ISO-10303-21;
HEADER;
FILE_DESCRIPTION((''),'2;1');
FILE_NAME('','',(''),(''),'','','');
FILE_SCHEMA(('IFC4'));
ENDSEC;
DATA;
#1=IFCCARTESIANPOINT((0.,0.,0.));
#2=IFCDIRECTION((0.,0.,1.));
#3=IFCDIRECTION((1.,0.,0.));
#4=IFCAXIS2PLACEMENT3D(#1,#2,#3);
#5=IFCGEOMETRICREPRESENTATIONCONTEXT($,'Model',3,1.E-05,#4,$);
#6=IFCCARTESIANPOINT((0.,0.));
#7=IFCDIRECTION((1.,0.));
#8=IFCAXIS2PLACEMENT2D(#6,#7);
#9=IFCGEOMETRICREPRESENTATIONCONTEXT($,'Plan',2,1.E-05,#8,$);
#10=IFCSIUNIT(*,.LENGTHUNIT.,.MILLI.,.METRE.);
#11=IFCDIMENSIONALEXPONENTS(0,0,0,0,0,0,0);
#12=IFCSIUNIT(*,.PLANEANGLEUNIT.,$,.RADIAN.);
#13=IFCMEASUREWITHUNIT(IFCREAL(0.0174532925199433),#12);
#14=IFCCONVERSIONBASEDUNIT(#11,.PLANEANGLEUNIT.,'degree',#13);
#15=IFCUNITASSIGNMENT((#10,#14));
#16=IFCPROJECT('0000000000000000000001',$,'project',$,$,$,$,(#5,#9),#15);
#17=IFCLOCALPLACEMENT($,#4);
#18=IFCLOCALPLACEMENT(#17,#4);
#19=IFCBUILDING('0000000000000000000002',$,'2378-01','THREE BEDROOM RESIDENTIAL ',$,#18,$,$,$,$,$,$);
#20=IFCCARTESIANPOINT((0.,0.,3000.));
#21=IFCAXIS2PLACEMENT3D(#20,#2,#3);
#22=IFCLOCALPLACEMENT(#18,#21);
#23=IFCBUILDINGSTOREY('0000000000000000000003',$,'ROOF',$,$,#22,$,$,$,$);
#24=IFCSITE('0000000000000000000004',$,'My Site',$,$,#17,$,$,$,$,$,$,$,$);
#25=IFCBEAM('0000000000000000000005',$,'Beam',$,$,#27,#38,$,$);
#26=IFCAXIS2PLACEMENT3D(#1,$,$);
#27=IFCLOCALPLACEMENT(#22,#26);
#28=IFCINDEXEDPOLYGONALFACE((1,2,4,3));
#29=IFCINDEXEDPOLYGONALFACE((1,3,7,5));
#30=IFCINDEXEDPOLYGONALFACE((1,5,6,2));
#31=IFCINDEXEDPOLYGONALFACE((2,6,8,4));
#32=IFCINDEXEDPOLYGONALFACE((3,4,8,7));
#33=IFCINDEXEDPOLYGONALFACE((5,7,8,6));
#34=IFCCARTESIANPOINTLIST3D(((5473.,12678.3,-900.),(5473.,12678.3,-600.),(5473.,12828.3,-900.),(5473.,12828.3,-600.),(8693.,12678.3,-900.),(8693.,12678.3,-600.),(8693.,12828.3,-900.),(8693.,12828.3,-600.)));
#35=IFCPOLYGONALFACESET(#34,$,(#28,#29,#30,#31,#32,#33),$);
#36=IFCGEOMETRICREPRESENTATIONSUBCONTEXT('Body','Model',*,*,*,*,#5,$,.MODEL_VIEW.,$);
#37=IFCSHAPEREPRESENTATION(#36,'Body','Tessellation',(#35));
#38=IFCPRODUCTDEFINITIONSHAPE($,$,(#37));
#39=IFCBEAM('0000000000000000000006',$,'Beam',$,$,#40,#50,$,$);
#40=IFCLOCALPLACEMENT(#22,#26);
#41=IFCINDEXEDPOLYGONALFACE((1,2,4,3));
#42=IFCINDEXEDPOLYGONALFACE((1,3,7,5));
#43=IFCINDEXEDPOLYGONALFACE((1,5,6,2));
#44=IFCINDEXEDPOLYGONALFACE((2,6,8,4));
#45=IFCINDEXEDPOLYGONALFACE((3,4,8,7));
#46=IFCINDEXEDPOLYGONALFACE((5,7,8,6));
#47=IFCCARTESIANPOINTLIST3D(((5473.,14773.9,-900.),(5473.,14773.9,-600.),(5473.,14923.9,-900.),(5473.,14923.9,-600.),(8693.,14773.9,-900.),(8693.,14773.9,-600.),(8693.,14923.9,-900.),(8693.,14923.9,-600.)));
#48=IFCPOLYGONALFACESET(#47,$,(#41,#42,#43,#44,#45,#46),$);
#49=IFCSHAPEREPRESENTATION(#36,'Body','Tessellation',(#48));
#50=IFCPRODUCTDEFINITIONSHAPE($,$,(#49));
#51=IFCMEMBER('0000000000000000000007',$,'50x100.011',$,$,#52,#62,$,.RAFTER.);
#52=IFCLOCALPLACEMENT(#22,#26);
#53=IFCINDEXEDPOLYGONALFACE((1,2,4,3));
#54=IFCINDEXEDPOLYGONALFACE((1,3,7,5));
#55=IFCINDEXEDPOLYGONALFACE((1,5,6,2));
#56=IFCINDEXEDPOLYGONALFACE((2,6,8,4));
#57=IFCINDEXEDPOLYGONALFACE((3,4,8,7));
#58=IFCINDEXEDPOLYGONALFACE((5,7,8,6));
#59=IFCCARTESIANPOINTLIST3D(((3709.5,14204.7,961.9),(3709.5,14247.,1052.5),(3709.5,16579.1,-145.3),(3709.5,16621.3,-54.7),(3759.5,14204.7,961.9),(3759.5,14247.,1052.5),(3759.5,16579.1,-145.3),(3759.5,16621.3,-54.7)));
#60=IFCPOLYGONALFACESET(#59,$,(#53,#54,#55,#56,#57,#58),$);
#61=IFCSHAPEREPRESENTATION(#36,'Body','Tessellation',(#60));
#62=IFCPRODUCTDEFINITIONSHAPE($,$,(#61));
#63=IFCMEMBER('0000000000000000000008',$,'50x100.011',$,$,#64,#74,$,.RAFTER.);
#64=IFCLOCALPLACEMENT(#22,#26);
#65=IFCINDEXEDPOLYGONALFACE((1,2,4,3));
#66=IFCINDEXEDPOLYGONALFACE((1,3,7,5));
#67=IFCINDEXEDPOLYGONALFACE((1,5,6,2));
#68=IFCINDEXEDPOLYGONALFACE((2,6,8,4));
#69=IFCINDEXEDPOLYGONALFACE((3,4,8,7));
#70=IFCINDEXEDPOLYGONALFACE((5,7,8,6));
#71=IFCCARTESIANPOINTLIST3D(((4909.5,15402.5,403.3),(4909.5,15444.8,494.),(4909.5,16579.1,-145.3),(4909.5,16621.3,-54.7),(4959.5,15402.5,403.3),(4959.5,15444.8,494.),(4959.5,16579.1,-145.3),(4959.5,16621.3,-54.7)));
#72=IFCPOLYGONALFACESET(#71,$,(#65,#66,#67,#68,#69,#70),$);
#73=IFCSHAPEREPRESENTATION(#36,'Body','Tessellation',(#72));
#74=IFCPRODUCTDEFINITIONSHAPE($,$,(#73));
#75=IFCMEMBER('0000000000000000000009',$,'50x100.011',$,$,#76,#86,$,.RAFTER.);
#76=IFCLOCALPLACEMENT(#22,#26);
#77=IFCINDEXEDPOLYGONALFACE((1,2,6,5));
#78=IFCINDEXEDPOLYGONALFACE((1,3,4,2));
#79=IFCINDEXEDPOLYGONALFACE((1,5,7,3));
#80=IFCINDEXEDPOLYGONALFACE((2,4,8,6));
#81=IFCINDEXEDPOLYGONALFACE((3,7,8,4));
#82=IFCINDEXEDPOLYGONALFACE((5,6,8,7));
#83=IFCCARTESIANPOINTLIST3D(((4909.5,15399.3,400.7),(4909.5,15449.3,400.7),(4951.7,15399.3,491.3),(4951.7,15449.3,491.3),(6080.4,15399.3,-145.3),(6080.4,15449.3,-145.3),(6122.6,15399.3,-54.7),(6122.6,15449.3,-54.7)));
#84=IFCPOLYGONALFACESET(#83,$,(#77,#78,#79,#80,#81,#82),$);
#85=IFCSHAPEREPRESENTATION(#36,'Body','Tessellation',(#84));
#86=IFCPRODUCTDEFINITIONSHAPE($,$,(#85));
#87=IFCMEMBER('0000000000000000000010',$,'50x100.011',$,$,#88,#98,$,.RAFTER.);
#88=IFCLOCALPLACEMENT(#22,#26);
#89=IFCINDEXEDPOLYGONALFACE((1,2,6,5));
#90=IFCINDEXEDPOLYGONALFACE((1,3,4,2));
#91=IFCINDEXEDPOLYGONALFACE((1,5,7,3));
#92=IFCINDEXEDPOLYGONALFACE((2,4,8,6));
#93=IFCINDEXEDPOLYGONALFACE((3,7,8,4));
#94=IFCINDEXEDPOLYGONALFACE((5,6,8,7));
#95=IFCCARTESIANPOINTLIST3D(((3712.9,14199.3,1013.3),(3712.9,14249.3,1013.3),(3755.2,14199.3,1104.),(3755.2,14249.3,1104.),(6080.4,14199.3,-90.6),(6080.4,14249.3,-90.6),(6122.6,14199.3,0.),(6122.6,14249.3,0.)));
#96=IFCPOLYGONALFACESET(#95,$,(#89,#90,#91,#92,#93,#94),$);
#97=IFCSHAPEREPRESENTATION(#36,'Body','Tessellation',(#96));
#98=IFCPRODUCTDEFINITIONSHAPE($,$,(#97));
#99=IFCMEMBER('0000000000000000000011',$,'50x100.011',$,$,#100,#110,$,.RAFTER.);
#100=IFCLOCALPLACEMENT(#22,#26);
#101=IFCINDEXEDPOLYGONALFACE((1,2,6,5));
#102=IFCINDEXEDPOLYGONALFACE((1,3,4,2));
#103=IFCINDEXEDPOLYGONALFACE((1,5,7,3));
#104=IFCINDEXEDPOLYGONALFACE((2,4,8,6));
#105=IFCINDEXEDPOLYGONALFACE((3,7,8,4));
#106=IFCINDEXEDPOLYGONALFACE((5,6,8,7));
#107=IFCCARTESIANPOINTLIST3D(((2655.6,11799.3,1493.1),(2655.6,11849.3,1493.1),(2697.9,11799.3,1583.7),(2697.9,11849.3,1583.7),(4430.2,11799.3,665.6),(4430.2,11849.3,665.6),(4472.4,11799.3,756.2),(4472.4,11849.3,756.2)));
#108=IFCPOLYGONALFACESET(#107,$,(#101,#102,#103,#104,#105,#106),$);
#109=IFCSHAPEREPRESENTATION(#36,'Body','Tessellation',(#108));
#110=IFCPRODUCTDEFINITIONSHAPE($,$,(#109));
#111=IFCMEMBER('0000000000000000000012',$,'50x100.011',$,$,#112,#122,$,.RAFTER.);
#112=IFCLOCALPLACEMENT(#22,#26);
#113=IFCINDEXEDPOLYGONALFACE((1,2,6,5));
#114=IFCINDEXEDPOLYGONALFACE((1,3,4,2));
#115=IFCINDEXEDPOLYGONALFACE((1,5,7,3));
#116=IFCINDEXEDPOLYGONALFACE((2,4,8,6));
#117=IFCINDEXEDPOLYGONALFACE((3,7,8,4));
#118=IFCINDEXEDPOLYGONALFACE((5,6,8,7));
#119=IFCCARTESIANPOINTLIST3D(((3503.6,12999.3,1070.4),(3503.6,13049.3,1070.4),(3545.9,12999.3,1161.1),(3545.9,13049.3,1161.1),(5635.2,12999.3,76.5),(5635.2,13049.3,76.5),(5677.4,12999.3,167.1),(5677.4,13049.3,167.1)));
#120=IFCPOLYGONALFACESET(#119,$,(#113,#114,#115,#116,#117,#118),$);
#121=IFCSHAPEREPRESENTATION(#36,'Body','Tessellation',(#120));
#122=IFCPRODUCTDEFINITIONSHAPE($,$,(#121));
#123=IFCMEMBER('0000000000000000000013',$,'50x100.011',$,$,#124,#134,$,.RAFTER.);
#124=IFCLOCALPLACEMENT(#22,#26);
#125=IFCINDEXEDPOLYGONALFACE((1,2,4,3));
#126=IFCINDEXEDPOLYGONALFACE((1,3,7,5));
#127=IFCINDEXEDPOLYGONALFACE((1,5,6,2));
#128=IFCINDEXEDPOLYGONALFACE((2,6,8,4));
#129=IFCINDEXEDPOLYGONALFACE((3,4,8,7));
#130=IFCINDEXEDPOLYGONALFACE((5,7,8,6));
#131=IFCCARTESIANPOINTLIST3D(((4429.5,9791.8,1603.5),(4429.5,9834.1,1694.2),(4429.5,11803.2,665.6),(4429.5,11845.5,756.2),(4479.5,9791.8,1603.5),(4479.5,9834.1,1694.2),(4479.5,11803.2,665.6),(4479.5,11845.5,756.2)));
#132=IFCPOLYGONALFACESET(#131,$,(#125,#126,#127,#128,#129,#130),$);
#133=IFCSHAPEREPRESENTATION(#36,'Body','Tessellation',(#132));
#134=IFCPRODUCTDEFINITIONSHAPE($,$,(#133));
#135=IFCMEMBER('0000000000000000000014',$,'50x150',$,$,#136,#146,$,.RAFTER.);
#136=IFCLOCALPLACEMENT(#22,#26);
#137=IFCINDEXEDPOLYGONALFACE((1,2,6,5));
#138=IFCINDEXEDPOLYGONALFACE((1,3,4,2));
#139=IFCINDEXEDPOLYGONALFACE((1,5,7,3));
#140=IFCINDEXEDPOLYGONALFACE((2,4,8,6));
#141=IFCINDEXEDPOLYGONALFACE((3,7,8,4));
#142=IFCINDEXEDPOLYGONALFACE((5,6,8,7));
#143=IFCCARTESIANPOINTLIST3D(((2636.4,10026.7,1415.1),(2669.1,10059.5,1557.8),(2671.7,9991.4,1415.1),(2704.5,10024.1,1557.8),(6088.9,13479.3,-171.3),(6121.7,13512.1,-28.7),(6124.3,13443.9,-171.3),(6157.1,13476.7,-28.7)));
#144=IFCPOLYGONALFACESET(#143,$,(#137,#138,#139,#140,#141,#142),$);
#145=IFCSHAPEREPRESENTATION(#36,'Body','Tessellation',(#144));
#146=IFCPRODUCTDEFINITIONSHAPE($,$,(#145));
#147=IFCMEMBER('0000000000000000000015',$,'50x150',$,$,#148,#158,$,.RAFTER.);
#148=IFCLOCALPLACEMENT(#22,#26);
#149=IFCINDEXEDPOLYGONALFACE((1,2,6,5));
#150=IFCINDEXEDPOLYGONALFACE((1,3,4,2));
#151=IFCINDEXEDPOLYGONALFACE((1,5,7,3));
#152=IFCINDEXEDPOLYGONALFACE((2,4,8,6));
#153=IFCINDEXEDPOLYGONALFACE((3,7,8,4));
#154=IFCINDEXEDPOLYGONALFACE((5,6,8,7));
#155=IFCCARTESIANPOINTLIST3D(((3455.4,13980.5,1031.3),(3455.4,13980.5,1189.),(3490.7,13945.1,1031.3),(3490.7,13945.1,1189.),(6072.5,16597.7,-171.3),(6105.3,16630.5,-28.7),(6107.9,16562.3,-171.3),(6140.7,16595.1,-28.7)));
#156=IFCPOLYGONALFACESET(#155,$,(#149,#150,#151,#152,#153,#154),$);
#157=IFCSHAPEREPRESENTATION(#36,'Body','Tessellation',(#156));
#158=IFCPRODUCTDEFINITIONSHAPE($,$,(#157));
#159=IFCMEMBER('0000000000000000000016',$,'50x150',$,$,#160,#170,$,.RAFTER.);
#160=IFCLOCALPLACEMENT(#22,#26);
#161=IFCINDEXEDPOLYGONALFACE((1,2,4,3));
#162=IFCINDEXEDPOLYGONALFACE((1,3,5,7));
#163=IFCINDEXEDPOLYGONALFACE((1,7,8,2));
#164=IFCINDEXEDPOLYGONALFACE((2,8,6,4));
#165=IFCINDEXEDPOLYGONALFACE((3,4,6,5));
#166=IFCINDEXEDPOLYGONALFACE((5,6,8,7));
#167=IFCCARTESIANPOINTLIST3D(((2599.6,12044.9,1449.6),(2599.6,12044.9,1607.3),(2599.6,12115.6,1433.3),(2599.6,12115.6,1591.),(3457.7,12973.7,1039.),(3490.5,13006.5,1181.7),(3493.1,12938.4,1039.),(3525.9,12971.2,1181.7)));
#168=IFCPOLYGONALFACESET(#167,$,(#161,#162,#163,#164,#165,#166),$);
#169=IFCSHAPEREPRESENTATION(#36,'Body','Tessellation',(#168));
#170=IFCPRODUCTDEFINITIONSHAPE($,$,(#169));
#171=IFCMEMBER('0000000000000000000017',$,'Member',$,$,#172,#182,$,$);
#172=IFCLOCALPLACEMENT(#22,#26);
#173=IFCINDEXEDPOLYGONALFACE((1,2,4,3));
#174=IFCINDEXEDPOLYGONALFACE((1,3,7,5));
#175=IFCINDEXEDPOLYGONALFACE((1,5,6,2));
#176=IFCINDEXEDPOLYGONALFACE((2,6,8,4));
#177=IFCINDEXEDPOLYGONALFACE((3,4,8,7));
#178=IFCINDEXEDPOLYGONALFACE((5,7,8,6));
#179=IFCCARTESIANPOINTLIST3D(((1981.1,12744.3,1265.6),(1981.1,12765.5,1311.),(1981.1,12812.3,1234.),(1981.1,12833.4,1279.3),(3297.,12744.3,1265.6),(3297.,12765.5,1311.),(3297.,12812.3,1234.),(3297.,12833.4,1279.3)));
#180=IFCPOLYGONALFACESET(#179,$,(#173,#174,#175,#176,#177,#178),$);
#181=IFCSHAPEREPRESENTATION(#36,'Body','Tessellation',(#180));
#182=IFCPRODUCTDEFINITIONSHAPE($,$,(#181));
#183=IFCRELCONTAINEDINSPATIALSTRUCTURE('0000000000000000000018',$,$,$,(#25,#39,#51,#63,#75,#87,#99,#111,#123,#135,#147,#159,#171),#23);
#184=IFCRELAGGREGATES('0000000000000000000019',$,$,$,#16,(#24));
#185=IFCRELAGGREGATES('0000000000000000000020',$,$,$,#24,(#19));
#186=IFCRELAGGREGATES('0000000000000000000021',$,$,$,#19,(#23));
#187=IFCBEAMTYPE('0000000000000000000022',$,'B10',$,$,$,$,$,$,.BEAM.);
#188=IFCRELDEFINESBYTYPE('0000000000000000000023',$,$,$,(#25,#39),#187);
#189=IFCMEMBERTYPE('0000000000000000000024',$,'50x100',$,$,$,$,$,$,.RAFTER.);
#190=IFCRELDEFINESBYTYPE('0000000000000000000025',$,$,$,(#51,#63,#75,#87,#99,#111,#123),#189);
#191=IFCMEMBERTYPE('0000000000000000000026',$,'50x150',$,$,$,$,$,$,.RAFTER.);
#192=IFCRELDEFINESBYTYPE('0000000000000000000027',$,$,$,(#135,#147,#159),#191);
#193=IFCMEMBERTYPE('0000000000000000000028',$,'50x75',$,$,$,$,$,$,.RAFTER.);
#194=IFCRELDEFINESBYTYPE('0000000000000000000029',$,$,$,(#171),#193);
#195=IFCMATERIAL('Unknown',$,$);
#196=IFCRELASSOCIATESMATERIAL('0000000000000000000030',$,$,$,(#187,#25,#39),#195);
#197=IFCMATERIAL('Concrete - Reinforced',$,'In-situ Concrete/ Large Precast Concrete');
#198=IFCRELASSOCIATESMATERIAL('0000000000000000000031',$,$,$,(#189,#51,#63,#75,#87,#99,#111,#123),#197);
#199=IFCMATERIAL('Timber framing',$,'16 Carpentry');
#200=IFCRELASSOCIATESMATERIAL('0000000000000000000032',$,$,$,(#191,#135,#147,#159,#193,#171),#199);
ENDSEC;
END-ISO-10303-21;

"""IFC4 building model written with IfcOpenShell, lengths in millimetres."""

from ifc_helpers import new_model, entity, si_unit, converted_unit, frame, origin_with_axes, origin_2d_with_axis, place, context, subcontext, project, spatial, rectangle, extrude, clip, halfspace, material, material_profile, profile_set, profile_usage, type_object, element, save


model = new_model("IFC4")

# Units and contexts
model_context = context("Model", 3, precision=1e-05, world=origin_with_axes())
plan_context = context("Plan", 2, precision=1e-05, world=origin_2d_with_axis())
body_context = subcontext(model_context, "Body", "Model", "MODEL_VIEW")
ifc_project = project(units=[si_unit("LENGTHUNIT", "METRE", prefix="MILLI"), converted_unit("PLANEANGLEUNIT", "degree", entity("IfcReal", 0.0174532925199433), si_unit("PLANEANGLEUNIT", "RADIAN"), dimensions=[0, 0, 0, 0, 0, 0, 0])], contexts=[model_context, plan_context])

# Site, building, storey
site_placement = place(None, origin_with_axes())
site = spatial("IfcSite", under=ifc_project, at=site_placement, Name="My Site")
building_placement = place(site_placement, origin_with_axes())
building = spatial("IfcBuilding", under=site, at=building_placement, Name="2378-01", Description="THREE BEDROOM RESIDENTIAL ")
storey_placement = place(building_placement, frame((0.0, 0.0, 3000.0), z_axis=(0.0, 0.0, 1.0), x_axis=(1.0, 0.0, 0.0)))
storey = spatial("IfcBuildingStorey", under=building, at=storey_placement, Name="ROOF")

# Beams
ifc_material_1 = material(Name="Unknown")
ifc_material_profile_1 = material_profile(ifc_material_1, rectangle(XDim=150.0, YDim=300.0))
ifc_profile_set_1 = profile_set([ifc_material_profile_1])
ifc_profile_usage_1 = profile_usage(ifc_profile_set_1, cardinal=5)
beam_type = type_object("IfcBeamType", Name="B10", PredefinedType="BEAM", material=ifc_profile_set_1)
beam_1_placement = place(storey_placement, frame((5473.0, 12753.3, -750.0), z_axis=(1.0, 0.0, 0.0), x_axis=(0.0, 1.0, 0.0)))
element("IfcBeam", 1, at=beam_1_placement, inside=storey, type_object=beam_type, material=ifc_profile_usage_1, Name="Beam", context=body_context, shape_type="SweptSolid", body=[
    extrude(rectangle(XDim=150.0, YDim=300.0), origin_with_axes(), (0.0, 0.0, 1.0), 3220.0),
])
ifc_profile_usage_2 = profile_usage(ifc_profile_set_1, cardinal=5)
beam_2_placement = place(storey_placement, frame((5473.0, 14848.9, -750.0), z_axis=(1.0, 0.0, 0.0), x_axis=(0.0, 1.0, 0.0)))
element("IfcBeam", 2, at=beam_2_placement, inside=storey, type_object=beam_type, material=ifc_profile_usage_2, Name="Beam", context=body_context, shape_type="SweptSolid", body=[
    extrude(rectangle(XDim=150.0, YDim=300.0), origin_with_axes(), (0.0, 0.0, 1.0), 3220.0),
])

# Members
ifc_material_2 = material(Name="Concrete - Reinforced", Category="In-situ Concrete/ Large Precast Concrete")
ifc_material_profile_2 = material_profile(ifc_material_2, rectangle(XDim=50.0, YDim=100.0), Name="Core Layer", Category="LoadBearing", Priority=1)
ifc_profile_set_2 = profile_set([ifc_material_profile_2], Name="wood")
ifc_profile_usage_3 = profile_usage(ifc_profile_set_2)
member_type_1 = type_object("IfcMemberType", Name="50x100", PredefinedType="RAFTER", material=ifc_profile_set_2)
member_1_placement = place(storey_placement, frame((3734.5, 16600.2, -100.0), z_axis=(0.0, -0.906308, 0.422618), x_axis=(1.0, 0.0, 0.0)))
element("IfcMember", 3, at=member_1_placement, inside=storey, type_object=member_type_1, material=ifc_profile_usage_3, Name="50x100.011", PredefinedType="RAFTER", context=body_context, shape_type="SweptSolid", body=[
    extrude(rectangle(XDim=50.0, YDim=100.0), origin_with_axes(), (0.0, 0.0, 1.0), 2619.8),
])
ifc_profile_usage_4 = profile_usage(ifc_profile_set_2)
member_2_placement = place(storey_placement, frame((4934.5, 16600.2, -100.0), z_axis=(0.0, -0.906308, 0.422618), x_axis=(1.0, 0.0, 0.0)))
element("IfcMember", 4, at=member_2_placement, inside=storey, type_object=member_type_1, material=ifc_profile_usage_4, Name="50x100.011", PredefinedType="RAFTER", context=body_context, shape_type="SweptSolid", body=[
    extrude(rectangle(XDim=50.0, YDim=100.0), origin_with_axes(), (0.0, 0.0, 1.0), 1298.2),
])
ifc_profile_usage_5 = profile_usage(ifc_profile_set_2)
member_3_placement = place(storey_placement, frame((6101.5, 15424.3, -100.0), z_axis=(-0.906308, 0.0, 0.422618), x_axis=(0.0, -1.0, 0.0)))
element("IfcMember", 5, at=member_3_placement, inside=storey, type_object=member_type_1, material=ifc_profile_usage_5, Name="50x100.011", PredefinedType="RAFTER", context=body_context, shape_type="SweptSolid", body=[
    extrude(rectangle(XDim=50.0, YDim=100.0), origin_with_axes(), (0.0, 0.0, 1.0), 1292.0),
])
ifc_profile_usage_6 = profile_usage(ifc_profile_set_2)
member_4_placement = place(storey_placement, frame((6101.5, 14224.3, -45.3), z_axis=(-0.906308, 0.0, 0.422618), x_axis=(0.0, -1.0, 0.0)))
element("IfcMember", 6, at=member_4_placement, inside=storey, type_object=member_type_1, material=ifc_profile_usage_6, Name="50x100.011", PredefinedType="RAFTER", context=body_context, shape_type="SweptSolid", body=[
    extrude(rectangle(XDim=50.0, YDim=100.0), origin_with_axes(), (0.0, 0.0, 1.0), 2612.2),
])
ifc_profile_usage_7 = profile_usage(ifc_profile_set_2)
member_5_placement = place(storey_placement, frame((4451.3, 11824.3, 710.9), z_axis=(-0.906308, 0.0, 0.422618), x_axis=(0.0, -1.0, 0.0)))
element("IfcMember", 7, at=member_5_placement, inside=storey, type_object=member_type_1, material=ifc_profile_usage_7, Name="50x100.011", PredefinedType="RAFTER", context=body_context, shape_type="SweptSolid", body=[
    extrude(rectangle(XDim=50.0, YDim=100.0), origin_with_axes(), (0.0, 0.0, 1.0), 1958.0),
])
ifc_profile_usage_8 = profile_usage(ifc_profile_set_2)
member_6_placement = place(storey_placement, frame((5656.3, 13024.3, 121.8), z_axis=(-0.906308, 0.0, 0.422618), x_axis=(0.0, -1.0, 0.0)))
element("IfcMember", 8, at=member_6_placement, inside=storey, type_object=member_type_1, material=ifc_profile_usage_8, Name="50x100.011", PredefinedType="RAFTER", context=body_context, shape_type="SweptSolid", body=[
    extrude(rectangle(XDim=50.0, YDim=100.0), origin_with_axes(), (0.0, 0.0, 1.0), 2351.9),
])
ifc_profile_usage_9 = profile_usage(ifc_profile_set_2)
member_7_placement = place(storey_placement, frame((4454.5, 11824.3, 710.9), z_axis=(0.0, -0.906308, 0.422618), x_axis=(1.0, 0.0, 0.0)))
element("IfcMember", 9, at=member_7_placement, inside=storey, type_object=member_type_1, material=ifc_profile_usage_9, Name="50x100.011", PredefinedType="RAFTER", context=body_context, shape_type="SweptSolid", body=[
    extrude(rectangle(XDim=50.0, YDim=100.0), origin_with_axes(), (0.0, 0.0, 1.0), 2219.4),
])
ifc_material_3 = material(Name="Timber framing", Category="16 Carpentry")
ifc_material_profile_3 = material_profile(ifc_material_3, rectangle(XDim=50.0, YDim=150.0), Name="Lumber", Category="LoadBearing", Priority=1)
ifc_profile_set_3 = profile_set([ifc_material_profile_3], Name="wood")
ifc_profile_usage_10 = profile_usage(ifc_profile_set_3)
member_type_2 = type_object("IfcMemberType", Name="50x150", PredefinedType="RAFTER", material=ifc_profile_set_3)
member_8_placement = place(storey_placement, frame((6123.0, 13478.0, -100.0), z_axis=(-0.672499, -0.672498, 0.309017), x_axis=(0.707107, -0.707107, 0.0)))
element("IfcMember", 10, at=member_8_placement, inside=storey, type_object=member_type_2, material=ifc_profile_usage_10, Name="50x150", PredefinedType="RAFTER", context=body_context, shape_type="SweptSolid", body=[
    extrude(rectangle(XDim=50.0, YDim=150.0), origin_with_axes(), (0.0, 0.0, 1.0), 5133.9),
])
ifc_profile_usage_11 = profile_usage(ifc_profile_set_3)
member_9_placement = place(storey_placement, frame((6106.6, 16596.4, -100.0), z_axis=(-0.672499, -0.672498, 0.309017), x_axis=(0.707107, -0.707107, 0.0)))
element("IfcMember", 11, at=member_9_placement, inside=storey, type_object=member_type_2, material=ifc_profile_usage_11, Name="50x150", PredefinedType="RAFTER", context=body_context, shape_type="Clipping", body=[
    clip(extrude(rectangle(XDim=50.0, YDim=150.0), origin_with_axes(), (0.0, 0.0, 1.0), 4066.1), halfspace(frame((-3717.1, -1150.9, 3542.2), z_axis=(0.0, -0.309017, 0.951057), x_axis=(-1.0, 0.0, 0.0)), False)),
])
ifc_profile_usage_12 = profile_usage(ifc_profile_set_3)
member_10_placement = place(storey_placement, frame((3491.8, 12972.4, 1110.3), z_axis=(-0.672499, -0.672498, 0.309017), x_axis=(0.707107, -0.707107, 0.0)))
element("IfcMember", 12, at=member_10_placement, inside=storey, type_object=member_type_2, material=ifc_profile_usage_12, Name="50x150", PredefinedType="RAFTER", context=body_context, shape_type="Clipping", body=[
    clip(extrude(rectangle(XDim=50.0, YDim=150.0), origin_with_axes(), (0.0, 0.0, 1.0), 1476.6), halfspace(frame((-17.7, 0.1, 1308.1), z_axis=(-0.707107, -0.218508, 0.672499), x_axis=(-0.295242, 0.955423, 0.0)), False)),
])
ifc_material_profile_4 = material_profile(ifc_material_3, rectangle(XDim=50.0, YDim=75.0), Name="Lumber2", Category="Substrate", Priority=2)
ifc_profile_set_4 = profile_set([ifc_material_profile_4])
ifc_profile_usage_13 = profile_usage(ifc_profile_set_4, cardinal=5)
member_type_3 = type_object("IfcMemberType", Name="50x75", PredefinedType="RAFTER", material=ifc_profile_set_4)
member_11_placement = place(storey_placement, frame((3297.0, 12788.9, 1272.5), z_axis=(-1.0, 0.0, 0.0), x_axis=(0.0, -0.422618, -0.906308)))
element("IfcMember", 13, at=member_11_placement, inside=storey, type_object=member_type_3, material=ifc_profile_usage_13, Name="Member", context=body_context, shape_type="SweptSolid", body=[
    extrude(rectangle(XDim=50.0, YDim=75.0), origin_with_axes(), (0.0, 0.0, 1.0), 1315.9),
])

save(model, "model.ifc")
